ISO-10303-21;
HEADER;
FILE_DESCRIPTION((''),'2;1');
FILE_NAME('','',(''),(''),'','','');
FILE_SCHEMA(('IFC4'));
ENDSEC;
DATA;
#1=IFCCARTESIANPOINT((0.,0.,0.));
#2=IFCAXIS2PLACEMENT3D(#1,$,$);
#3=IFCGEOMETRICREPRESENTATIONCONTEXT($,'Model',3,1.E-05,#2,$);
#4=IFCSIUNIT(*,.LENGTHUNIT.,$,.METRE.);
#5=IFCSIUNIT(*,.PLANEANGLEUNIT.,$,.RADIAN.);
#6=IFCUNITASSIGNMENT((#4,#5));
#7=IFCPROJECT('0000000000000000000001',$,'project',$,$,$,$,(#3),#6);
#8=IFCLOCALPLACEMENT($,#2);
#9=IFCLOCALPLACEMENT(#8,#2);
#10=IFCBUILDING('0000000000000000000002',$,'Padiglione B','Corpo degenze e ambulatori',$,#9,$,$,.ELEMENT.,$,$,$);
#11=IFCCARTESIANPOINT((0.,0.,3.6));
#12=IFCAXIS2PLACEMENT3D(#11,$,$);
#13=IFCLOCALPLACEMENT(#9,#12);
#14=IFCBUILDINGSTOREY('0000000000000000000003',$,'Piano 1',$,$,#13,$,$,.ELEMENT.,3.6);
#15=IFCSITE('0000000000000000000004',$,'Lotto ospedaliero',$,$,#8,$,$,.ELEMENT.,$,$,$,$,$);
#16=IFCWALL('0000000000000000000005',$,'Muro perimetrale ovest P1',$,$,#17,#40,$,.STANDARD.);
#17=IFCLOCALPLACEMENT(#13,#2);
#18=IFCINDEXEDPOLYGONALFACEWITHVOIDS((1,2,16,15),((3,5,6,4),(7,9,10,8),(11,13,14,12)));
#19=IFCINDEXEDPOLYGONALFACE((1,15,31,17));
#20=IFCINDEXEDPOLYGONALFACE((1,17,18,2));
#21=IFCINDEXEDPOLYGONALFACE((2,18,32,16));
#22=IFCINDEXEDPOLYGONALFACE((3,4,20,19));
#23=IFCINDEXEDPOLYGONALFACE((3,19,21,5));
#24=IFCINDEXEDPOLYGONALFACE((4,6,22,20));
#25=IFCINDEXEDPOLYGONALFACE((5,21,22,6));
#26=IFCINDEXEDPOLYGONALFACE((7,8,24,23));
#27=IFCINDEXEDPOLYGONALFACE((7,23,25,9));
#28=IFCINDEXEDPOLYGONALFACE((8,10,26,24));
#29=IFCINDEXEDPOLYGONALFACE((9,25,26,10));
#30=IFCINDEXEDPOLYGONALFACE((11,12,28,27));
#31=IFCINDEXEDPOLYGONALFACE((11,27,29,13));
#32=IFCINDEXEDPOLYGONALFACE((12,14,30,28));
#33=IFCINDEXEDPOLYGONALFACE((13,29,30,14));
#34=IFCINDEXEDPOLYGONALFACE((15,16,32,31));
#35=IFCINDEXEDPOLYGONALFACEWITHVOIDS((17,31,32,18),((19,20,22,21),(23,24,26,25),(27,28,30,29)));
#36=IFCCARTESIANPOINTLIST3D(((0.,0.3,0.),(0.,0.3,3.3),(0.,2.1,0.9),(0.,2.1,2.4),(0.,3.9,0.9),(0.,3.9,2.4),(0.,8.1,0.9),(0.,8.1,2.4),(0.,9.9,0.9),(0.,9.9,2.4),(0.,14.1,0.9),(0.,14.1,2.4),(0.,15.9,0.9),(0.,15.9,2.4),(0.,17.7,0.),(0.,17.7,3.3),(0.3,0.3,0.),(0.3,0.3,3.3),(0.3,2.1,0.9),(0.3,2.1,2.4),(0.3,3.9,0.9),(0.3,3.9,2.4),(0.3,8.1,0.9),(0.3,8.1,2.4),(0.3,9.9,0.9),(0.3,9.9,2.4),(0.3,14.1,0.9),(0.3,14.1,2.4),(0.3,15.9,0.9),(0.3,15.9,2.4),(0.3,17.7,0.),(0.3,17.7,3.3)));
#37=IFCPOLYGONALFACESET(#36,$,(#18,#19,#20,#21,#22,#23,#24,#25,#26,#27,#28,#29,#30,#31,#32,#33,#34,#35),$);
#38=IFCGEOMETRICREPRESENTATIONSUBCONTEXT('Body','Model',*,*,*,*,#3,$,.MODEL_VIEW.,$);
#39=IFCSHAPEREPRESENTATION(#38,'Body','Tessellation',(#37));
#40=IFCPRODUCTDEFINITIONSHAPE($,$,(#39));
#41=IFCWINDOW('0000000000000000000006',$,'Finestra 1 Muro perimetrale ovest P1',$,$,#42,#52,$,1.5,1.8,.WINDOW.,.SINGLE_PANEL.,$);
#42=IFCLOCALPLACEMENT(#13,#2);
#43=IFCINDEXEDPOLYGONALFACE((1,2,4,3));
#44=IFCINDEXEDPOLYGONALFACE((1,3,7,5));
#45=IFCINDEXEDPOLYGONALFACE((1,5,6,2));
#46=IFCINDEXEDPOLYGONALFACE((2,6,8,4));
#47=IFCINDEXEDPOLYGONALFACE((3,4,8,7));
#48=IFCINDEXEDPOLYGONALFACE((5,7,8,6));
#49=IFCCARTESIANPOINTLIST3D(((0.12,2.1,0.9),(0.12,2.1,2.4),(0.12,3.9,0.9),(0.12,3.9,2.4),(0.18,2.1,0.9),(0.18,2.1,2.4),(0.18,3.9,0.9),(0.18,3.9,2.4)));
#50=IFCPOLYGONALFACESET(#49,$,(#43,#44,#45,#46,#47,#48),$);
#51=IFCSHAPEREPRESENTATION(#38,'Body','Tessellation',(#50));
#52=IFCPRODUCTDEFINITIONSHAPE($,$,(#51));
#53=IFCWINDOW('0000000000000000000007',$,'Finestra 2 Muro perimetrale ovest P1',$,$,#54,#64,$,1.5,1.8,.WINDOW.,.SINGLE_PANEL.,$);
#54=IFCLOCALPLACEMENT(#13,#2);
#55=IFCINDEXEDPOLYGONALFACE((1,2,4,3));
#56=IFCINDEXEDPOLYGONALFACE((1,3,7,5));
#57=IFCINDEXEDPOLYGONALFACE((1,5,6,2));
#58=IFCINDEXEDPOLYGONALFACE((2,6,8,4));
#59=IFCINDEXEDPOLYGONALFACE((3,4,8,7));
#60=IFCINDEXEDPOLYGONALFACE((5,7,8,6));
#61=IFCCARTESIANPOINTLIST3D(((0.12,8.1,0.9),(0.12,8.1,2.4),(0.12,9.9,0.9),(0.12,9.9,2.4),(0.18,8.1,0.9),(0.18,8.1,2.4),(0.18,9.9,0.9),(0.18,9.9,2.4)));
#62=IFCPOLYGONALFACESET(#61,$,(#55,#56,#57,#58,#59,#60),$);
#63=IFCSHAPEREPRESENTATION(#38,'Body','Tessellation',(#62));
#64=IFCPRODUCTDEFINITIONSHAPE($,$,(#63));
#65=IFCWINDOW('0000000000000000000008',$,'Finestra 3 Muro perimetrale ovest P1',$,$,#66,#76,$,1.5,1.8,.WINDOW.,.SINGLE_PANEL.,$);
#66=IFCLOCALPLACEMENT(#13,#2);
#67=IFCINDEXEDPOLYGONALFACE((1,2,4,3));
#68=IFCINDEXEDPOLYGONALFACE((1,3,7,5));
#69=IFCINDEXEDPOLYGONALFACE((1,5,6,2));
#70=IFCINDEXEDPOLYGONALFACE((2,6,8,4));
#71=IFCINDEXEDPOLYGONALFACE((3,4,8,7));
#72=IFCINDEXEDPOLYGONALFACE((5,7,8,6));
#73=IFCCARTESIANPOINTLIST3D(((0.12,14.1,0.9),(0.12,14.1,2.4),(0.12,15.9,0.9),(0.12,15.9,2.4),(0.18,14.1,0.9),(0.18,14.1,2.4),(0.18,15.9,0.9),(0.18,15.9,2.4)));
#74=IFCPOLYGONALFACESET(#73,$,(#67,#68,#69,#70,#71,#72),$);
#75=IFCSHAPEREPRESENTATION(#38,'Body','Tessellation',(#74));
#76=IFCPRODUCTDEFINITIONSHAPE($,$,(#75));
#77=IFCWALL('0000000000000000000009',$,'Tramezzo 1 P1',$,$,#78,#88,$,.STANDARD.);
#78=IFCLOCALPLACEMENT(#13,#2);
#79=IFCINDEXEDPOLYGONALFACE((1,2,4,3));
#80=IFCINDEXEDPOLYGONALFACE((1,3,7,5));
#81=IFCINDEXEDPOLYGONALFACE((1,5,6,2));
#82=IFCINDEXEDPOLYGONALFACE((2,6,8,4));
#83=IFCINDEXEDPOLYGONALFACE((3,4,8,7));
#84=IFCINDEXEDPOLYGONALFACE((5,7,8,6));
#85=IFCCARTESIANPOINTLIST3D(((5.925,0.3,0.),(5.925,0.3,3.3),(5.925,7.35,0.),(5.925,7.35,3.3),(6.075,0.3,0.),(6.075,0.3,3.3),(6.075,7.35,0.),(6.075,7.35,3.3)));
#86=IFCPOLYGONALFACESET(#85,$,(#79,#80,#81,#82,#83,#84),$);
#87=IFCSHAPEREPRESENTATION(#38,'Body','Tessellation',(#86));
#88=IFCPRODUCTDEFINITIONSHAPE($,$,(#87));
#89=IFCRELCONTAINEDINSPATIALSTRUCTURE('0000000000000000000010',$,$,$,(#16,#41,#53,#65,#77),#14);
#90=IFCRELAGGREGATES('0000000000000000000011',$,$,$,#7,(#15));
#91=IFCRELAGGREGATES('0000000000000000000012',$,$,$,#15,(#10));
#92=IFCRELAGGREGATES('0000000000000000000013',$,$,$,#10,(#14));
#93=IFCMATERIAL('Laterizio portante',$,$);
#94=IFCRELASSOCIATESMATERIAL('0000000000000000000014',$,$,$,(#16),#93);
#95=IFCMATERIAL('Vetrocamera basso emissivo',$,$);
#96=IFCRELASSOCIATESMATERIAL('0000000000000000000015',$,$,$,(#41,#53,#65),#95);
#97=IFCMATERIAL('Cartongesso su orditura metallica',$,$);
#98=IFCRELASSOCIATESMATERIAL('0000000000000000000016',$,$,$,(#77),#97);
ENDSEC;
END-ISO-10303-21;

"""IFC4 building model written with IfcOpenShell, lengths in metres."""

from ifc_helpers import new_model, si_unit, frame, frame_2d, origin, place, context, subcontext, project, spatial, rectangle, extrude, material, element, fill, save


model = new_model("IFC4")

# Units and contexts
model_context = context("Model", 3, precision=1e-05, world=origin())
body_context = subcontext(model_context, "Body", "Model", "MODEL_VIEW")
ifc_project = project(units=[si_unit("LENGTHUNIT", "METRE"), si_unit("PLANEANGLEUNIT", "RADIAN")], contexts=[model_context])

# Site, building, storey
site_placement = place(None, origin())
site = spatial("IfcSite", under=ifc_project, at=site_placement, Name="Lotto ospedaliero", CompositionType="ELEMENT")
building_placement = place(site_placement, origin())
building = spatial("IfcBuilding", under=site, at=building_placement, Name="Padiglione B", Description="Corpo degenze e ambulatori", CompositionType="ELEMENT")
storey_placement = place(building_placement, frame((0.0, 0.0, 3.6)))
storey = spatial("IfcBuildingStorey", under=building, at=storey_placement, Name="Piano 1", CompositionType="ELEMENT", Elevation=3.6)

# Wall, openings, windows
ifc_material_1 = material(Name="Laterizio portante")
ifc_material_2 = material(Name="Vetrocamera basso emissivo")
wall_1_placement = place(storey_placement, frame((0.0, 0.3, 0.0)))
wall_1 = element("IfcWall", 1, at=wall_1_placement, inside=storey, material=ifc_material_1, Name="Muro perimetrale ovest P1", PredefinedType="STANDARD", context=body_context, shape_type="SweptSolid", body=[
    extrude(rectangle(XDim=0.3, YDim=17.4, at=frame_2d((0.15, 8.7))), origin(), (0.0, 0.0, 1.0), 3.3),
])
opening_1_placement = place(wall_1_placement, frame((-0.1, 1.8, 0.9)))
opening_1 = element("IfcOpeningElement", 2, at=opening_1_placement, cuts=wall_1, PredefinedType="OPENING", context=body_context, shape_type="SweptSolid", body=[
    extrude(rectangle(XDim=0.5, YDim=1.8, at=frame_2d((0.25, 0.9))), origin(), (0.0, 0.0, 1.0), 1.5),
])
opening_2_placement = place(wall_1_placement, frame((-0.1, 7.8, 0.9)))
opening_2 = element("IfcOpeningElement", 3, at=opening_2_placement, cuts=wall_1, PredefinedType="OPENING", context=body_context, shape_type="SweptSolid", body=[
    extrude(rectangle(XDim=0.5, YDim=1.8, at=frame_2d((0.25, 0.9))), origin(), (0.0, 0.0, 1.0), 1.5),
])
opening_3_placement = place(wall_1_placement, frame((-0.1, 13.8, 0.9)))
opening_3 = element("IfcOpeningElement", 4, at=opening_3_placement, cuts=wall_1, PredefinedType="OPENING", context=body_context, shape_type="SweptSolid", body=[
    extrude(rectangle(XDim=0.5, YDim=1.8, at=frame_2d((0.25, 0.9))), origin(), (0.0, 0.0, 1.0), 1.5),
])
window_1_placement = place(wall_1_placement, frame((0.12, 1.8, 0.9)))
window_1 = element("IfcWindow", 5, at=window_1_placement, inside=storey, material=ifc_material_2, Name="Finestra 1 Muro perimetrale ovest P1", OverallHeight=1.5, OverallWidth=1.8, PartitioningType="SINGLE_PANEL", PredefinedType="WINDOW", context=body_context, shape_type="SweptSolid", body=[
    extrude(rectangle(XDim=0.06, YDim=1.8, at=frame_2d((0.03, 0.9))), origin(), (0.0, 0.0, 1.0), 1.5),
])
fill(opening_1, window_1)
window_2_placement = place(wall_1_placement, frame((0.12, 7.8, 0.9)))
window_2 = element("IfcWindow", 6, at=window_2_placement, inside=storey, material=ifc_material_2, Name="Finestra 2 Muro perimetrale ovest P1", OverallHeight=1.5, OverallWidth=1.8, PartitioningType="SINGLE_PANEL", PredefinedType="WINDOW", context=body_context, shape_type="SweptSolid", body=[
    extrude(rectangle(XDim=0.06, YDim=1.8, at=frame_2d((0.03, 0.9))), origin(), (0.0, 0.0, 1.0), 1.5),
])
fill(opening_2, window_2)
window_3_placement = place(wall_1_placement, frame((0.12, 13.8, 0.9)))
window_3 = element("IfcWindow", 7, at=window_3_placement, inside=storey, material=ifc_material_2, Name="Finestra 3 Muro perimetrale ovest P1", OverallHeight=1.5, OverallWidth=1.8, PartitioningType="SINGLE_PANEL", PredefinedType="WINDOW", context=body_context, shape_type="SweptSolid", body=[
    extrude(rectangle(XDim=0.06, YDim=1.8, at=frame_2d((0.03, 0.9))), origin(), (0.0, 0.0, 1.0), 1.5),
])
fill(opening_3, window_3)

# Wall
ifc_material_3 = material(Name="Cartongesso su orditura metallica")
wall_2_placement = place(storey_placement, frame((5.925, 0.3, 0.0)))
element("IfcWall", 8, at=wall_2_placement, inside=storey, material=ifc_material_3, Name="Tramezzo 1 P1", PredefinedType="STANDARD", context=body_context, shape_type="SweptSolid", body=[
    extrude(rectangle(XDim=0.15, YDim=7.05, at=frame_2d((0.075, 3.525))), origin(), (0.0, 0.0, 1.0), 3.3),
])

save(model, "model.ifc")
